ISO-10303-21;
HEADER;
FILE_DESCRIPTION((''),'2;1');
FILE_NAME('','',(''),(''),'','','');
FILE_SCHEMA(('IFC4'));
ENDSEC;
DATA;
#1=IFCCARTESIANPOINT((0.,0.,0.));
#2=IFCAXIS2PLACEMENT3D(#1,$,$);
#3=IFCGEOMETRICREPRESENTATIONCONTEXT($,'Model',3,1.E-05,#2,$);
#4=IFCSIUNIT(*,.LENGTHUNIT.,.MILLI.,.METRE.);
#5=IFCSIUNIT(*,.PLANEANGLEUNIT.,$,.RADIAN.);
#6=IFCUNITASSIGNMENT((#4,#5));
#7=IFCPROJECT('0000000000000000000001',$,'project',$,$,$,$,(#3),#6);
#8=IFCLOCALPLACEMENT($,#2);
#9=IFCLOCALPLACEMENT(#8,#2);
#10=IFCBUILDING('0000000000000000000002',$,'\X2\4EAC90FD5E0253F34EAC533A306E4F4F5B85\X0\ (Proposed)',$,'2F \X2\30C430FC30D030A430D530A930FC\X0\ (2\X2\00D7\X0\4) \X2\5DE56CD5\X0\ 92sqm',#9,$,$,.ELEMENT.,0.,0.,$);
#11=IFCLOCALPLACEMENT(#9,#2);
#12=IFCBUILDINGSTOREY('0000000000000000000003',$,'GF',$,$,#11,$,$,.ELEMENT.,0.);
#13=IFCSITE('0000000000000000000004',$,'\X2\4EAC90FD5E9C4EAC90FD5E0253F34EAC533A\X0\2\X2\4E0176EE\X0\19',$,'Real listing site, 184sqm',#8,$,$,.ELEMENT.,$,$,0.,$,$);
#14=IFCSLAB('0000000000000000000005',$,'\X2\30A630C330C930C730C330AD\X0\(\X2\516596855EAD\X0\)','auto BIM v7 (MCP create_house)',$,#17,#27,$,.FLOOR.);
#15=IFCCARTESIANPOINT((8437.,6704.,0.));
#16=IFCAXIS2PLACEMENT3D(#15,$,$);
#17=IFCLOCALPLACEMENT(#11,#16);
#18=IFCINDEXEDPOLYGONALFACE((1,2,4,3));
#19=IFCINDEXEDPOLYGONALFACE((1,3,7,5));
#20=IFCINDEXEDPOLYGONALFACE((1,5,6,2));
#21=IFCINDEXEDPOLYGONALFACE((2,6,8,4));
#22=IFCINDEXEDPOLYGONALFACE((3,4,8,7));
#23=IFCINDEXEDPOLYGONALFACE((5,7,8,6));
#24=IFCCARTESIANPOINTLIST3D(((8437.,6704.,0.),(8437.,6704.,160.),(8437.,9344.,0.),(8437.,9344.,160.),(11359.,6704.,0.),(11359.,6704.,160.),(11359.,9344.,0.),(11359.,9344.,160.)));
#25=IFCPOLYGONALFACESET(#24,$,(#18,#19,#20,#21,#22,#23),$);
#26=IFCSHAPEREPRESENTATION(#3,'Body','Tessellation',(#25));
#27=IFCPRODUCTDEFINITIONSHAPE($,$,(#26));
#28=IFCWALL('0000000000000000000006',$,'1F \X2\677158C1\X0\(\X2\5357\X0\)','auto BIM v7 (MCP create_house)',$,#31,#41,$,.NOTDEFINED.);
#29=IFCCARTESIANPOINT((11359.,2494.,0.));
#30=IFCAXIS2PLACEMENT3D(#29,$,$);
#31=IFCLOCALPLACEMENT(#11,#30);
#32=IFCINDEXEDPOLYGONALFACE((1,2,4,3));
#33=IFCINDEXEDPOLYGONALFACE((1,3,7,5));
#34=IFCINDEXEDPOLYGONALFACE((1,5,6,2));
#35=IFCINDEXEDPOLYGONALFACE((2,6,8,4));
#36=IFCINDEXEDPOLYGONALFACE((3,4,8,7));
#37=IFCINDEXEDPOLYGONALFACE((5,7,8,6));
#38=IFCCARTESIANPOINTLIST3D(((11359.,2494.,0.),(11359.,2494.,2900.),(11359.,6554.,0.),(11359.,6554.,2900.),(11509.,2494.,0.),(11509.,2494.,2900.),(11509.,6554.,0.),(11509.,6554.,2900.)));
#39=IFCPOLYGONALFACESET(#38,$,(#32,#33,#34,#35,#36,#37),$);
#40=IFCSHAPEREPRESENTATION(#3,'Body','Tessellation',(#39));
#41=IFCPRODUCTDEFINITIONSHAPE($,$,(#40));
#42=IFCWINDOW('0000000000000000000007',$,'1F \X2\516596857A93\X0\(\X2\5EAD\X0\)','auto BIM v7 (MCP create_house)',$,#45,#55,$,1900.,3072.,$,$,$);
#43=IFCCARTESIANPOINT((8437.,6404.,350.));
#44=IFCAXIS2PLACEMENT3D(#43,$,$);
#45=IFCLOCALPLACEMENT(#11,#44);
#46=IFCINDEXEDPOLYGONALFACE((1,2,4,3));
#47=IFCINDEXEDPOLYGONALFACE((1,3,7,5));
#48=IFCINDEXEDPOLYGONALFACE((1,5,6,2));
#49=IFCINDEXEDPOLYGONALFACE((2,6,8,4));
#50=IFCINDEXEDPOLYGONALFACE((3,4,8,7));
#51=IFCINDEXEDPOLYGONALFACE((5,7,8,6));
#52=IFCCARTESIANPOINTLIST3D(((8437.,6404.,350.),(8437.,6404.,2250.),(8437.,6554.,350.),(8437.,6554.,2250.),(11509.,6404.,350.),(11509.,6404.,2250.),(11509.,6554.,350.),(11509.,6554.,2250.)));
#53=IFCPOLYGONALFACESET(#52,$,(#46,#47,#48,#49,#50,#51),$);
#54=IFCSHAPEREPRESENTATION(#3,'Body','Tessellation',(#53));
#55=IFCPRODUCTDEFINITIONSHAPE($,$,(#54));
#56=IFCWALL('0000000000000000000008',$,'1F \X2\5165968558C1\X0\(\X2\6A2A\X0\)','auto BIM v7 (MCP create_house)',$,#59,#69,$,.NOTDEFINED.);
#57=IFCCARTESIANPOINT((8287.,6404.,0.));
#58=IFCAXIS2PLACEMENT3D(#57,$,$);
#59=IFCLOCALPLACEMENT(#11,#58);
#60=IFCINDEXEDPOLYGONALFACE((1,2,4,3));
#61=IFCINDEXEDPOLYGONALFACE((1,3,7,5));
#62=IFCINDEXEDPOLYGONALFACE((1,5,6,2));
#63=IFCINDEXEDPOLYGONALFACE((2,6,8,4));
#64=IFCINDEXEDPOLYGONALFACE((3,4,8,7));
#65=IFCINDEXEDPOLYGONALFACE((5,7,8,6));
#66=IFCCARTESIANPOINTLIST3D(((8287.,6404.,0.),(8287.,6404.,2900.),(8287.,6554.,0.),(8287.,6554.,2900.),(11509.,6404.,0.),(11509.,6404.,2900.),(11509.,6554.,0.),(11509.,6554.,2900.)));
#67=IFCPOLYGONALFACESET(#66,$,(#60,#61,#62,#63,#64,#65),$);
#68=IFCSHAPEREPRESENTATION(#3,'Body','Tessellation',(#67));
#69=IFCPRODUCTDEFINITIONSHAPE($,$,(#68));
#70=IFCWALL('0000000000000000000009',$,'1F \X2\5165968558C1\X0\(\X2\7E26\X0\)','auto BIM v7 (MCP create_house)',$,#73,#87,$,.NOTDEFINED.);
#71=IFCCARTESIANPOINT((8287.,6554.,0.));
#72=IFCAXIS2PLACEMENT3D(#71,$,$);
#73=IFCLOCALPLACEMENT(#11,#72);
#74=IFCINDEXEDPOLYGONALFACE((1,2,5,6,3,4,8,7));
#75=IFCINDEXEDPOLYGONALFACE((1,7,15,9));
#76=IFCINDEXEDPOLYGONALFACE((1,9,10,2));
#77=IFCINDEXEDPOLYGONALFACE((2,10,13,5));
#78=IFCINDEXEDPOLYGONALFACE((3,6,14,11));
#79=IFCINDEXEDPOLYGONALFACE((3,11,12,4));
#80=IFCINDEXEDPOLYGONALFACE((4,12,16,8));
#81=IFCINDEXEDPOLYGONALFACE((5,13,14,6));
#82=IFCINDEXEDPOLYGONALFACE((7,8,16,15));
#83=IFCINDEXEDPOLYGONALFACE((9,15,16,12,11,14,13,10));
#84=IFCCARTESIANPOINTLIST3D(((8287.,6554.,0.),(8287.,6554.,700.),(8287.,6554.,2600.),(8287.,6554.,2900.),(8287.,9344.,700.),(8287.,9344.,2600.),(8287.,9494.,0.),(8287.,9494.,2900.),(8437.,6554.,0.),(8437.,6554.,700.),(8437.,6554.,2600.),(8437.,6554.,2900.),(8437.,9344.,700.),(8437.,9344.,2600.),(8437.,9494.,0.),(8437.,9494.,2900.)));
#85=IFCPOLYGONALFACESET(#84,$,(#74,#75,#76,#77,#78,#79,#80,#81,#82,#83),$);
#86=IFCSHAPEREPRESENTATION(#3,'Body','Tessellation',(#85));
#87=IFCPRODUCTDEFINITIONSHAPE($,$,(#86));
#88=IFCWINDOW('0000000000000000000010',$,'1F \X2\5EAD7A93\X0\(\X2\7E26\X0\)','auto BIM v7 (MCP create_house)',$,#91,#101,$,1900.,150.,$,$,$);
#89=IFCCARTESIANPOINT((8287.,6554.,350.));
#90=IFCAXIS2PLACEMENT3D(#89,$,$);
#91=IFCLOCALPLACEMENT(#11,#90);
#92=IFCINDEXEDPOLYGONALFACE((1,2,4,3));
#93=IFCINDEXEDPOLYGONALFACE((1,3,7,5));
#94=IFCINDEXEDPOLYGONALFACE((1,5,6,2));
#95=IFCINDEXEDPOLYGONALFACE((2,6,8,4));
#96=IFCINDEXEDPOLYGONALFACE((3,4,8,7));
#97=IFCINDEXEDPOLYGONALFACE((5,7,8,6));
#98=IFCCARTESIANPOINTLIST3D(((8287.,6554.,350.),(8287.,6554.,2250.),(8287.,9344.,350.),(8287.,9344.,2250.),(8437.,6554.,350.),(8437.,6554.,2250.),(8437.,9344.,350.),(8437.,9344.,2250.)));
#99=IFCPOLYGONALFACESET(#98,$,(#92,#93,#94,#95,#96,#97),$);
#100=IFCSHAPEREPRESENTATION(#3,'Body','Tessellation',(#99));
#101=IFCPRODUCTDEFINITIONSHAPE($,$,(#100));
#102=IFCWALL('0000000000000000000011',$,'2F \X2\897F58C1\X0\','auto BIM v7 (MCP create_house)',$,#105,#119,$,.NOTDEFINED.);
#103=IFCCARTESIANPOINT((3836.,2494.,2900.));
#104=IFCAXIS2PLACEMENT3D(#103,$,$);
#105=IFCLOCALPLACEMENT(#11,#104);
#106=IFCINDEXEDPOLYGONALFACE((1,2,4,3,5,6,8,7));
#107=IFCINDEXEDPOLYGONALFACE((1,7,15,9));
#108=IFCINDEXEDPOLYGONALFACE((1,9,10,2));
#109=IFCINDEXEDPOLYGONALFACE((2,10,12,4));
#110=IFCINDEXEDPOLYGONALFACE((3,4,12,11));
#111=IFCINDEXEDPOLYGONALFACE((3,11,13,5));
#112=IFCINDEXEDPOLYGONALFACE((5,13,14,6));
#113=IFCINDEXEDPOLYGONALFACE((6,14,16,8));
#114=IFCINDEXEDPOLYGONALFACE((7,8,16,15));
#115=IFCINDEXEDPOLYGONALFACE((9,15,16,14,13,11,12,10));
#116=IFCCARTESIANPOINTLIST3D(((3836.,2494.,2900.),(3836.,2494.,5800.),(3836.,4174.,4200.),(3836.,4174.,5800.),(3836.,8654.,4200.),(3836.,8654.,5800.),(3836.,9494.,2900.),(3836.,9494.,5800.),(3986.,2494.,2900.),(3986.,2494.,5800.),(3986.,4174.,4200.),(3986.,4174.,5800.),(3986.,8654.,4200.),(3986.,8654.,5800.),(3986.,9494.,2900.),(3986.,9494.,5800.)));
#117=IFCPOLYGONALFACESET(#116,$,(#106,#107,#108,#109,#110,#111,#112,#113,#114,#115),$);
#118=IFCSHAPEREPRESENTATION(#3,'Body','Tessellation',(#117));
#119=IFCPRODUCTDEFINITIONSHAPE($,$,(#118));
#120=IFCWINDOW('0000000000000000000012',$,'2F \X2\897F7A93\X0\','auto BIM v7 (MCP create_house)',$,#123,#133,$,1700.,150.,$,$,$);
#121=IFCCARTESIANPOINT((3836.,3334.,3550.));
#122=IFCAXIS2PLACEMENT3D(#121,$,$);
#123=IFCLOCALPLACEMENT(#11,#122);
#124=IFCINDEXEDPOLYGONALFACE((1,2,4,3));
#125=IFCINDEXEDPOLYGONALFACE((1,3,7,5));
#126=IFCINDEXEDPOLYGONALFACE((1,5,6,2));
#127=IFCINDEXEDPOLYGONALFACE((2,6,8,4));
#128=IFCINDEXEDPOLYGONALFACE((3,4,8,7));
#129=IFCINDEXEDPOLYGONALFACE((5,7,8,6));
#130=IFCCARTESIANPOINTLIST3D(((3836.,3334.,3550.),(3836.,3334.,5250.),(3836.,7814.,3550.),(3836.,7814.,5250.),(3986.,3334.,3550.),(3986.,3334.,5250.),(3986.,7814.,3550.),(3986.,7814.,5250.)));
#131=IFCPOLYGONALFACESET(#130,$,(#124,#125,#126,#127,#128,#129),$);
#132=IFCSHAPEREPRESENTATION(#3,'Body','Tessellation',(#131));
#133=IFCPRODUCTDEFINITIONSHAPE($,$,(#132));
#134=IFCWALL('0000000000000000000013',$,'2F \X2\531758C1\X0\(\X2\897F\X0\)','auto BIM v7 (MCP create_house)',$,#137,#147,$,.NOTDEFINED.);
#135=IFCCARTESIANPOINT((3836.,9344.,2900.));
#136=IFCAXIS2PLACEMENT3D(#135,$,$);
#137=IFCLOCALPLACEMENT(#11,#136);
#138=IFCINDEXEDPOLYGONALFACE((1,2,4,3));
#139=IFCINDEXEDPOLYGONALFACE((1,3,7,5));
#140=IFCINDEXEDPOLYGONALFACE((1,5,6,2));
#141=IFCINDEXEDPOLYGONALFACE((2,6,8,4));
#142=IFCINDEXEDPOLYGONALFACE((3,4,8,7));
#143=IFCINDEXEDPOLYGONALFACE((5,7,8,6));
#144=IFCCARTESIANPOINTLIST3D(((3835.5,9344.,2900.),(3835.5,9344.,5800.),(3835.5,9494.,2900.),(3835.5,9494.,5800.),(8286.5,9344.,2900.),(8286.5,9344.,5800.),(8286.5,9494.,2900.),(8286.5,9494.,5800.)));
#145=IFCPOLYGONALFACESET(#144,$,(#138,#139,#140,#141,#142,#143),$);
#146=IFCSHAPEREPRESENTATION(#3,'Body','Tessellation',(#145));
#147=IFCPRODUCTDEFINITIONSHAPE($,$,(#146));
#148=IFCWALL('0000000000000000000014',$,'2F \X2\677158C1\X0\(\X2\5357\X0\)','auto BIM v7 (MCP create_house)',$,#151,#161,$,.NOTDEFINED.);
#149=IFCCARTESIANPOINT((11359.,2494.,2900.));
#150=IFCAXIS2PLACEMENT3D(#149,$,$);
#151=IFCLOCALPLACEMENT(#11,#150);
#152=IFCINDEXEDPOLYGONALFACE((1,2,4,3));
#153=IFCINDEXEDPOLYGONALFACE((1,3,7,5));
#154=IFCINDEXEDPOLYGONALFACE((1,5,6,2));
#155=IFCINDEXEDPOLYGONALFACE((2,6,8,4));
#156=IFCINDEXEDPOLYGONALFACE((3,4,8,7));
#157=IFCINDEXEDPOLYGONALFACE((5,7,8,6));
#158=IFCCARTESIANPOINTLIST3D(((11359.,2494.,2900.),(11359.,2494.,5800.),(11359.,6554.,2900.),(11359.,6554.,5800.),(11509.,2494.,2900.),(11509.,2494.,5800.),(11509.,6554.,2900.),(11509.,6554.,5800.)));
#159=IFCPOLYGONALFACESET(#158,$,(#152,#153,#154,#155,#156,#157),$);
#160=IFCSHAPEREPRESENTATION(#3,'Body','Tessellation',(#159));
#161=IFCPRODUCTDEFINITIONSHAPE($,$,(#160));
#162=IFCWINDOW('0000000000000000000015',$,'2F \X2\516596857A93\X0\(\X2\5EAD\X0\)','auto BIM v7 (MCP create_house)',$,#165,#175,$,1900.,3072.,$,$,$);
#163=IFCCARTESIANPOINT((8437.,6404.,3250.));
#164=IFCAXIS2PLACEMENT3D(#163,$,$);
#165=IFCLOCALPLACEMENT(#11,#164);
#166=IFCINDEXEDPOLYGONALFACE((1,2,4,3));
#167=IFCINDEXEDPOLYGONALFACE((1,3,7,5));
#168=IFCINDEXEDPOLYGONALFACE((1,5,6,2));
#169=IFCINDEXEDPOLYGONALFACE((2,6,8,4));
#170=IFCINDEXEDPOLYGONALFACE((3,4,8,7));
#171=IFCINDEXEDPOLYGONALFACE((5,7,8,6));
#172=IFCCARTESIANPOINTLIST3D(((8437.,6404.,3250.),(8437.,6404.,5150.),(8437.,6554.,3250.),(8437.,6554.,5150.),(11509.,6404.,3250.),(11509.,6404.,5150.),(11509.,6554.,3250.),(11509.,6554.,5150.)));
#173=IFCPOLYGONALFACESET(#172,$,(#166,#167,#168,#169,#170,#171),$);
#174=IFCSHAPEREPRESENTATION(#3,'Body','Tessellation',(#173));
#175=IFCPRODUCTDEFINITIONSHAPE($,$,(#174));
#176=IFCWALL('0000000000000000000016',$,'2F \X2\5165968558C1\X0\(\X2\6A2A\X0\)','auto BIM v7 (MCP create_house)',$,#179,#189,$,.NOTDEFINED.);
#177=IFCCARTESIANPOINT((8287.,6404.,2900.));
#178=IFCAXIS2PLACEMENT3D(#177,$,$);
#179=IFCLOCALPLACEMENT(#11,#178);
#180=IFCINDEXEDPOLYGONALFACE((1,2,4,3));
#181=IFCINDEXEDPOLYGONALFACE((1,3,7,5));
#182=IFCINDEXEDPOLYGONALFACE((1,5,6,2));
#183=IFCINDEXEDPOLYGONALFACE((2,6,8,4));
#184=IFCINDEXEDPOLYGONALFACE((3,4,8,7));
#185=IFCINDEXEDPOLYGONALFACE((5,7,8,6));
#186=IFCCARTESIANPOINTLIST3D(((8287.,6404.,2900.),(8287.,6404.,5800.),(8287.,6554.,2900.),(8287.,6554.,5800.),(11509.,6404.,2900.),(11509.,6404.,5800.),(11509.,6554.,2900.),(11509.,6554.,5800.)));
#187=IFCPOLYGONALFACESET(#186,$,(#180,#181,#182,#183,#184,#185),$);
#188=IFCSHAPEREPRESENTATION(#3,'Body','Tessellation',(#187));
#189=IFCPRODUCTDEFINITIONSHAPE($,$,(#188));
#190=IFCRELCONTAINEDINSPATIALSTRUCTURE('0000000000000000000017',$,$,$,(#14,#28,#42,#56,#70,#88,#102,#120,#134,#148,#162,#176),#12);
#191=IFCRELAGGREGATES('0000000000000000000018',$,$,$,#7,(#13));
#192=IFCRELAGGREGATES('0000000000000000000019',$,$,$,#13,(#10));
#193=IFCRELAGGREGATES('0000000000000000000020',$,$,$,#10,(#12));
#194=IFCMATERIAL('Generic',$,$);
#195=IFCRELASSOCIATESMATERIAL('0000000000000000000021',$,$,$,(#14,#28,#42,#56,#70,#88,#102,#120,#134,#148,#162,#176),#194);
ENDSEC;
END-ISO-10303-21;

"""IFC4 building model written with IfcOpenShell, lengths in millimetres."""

from ifc_helpers import new_model, si_unit, frame, frame_2d, origin, place, context, project, spatial, rectangle, extrude, material, element, fill, save


model = new_model("IFC4")

# Units and contexts
model_context = context("Model", 3, precision=1e-05, world=origin())
ifc_project = project(units=[si_unit("LENGTHUNIT", "METRE", prefix="MILLI"), si_unit("PLANEANGLEUNIT", "RADIAN")], contexts=[model_context])

# Site, building, storey
site_placement = place(None, origin())
site = spatial("IfcSite", under=ifc_project, at=site_placement, Name="京都府京都市右京区2丁目19", ObjectType="Real listing site, 184sqm", CompositionType="ELEMENT", RefElevation=0.0)
building_placement = place(site_placement, origin())
building = spatial("IfcBuilding", under=site, at=building_placement, Name="京都市右京区の住宅 (Proposed)", ObjectType="2F ツーバイフォー (2×4) 工法 92sqm", CompositionType="ELEMENT", ElevationOfRefHeight=0.0, ElevationOfTerrain=0.0)
storey_placement = place(building_placement, origin())
storey = spatial("IfcBuildingStorey", under=building, at=storey_placement, Name="GF", CompositionType="ELEMENT", Elevation=0.0)

# Slab
ifc_material = material(Name="Generic")
slab_placement = place(storey_placement, frame((8437.0, 6704.0, 0.0)))
element("IfcSlab", 1, at=slab_placement, inside=storey, material=ifc_material, Name="ウッドデッキ(入隅庭)", Description="auto BIM v7 (MCP create_house)", PredefinedType="FLOOR", context=model_context, shape_type="SweptSolid", body=[
    extrude(rectangle(XDim=2922.0, YDim=2640.0, at=frame_2d((1461.0, 1320.0))), frame((8437.0, 6704.0, 0.0)), (0.0, 0.0, 1.0), 160.0),
])

# Wall, opening, window
wall_1_placement = place(storey_placement, frame((11359.0, 2494.0, 0.0)))
wall_1 = element("IfcWall", 2, at=wall_1_placement, inside=storey, material=ifc_material, Name="1F 東壁(南)", Description="auto BIM v7 (MCP create_house)", PredefinedType="NOTDEFINED", context=model_context, shape_type="SweptSolid", body=[
    extrude(rectangle(XDim=150.0, YDim=4060.0, at=frame_2d((75.0, 2030.0))), frame((11359.0, 2494.0, 0.0)), (0.0, 0.0, 1.0), 2900.0),
])
opening_1_placement = place(storey_placement, frame((8437.0, 6404.0, 350.0)))
opening_1 = element("IfcOpeningElement", 3, at=opening_1_placement, cuts=wall_1, PredefinedType="NOTDEFINED", context=model_context, shape_type="SweptSolid", body=[
    extrude(rectangle(XDim=3072.0, YDim=150.0, at=frame_2d((1536.0, 75.0))), frame((8437.0, 6404.0, 350.0)), (0.0, 0.0, 1.0), 1900.0),
])
window_1_placement = place(storey_placement, frame((8437.0, 6404.0, 350.0)))
window_1 = element("IfcWindow", 4, at=window_1_placement, inside=storey, material=ifc_material, Name="1F 入隅窓(庭)", Description="auto BIM v7 (MCP create_house)", OverallHeight=1900.0, OverallWidth=3072.0, context=model_context, shape_type="SweptSolid", body=[
    extrude(rectangle(XDim=3072.0, YDim=150.0, at=frame_2d((1536.0, 75.0))), frame((8437.0, 6404.0, 350.0)), (0.0, 0.0, 1.0), 1900.0),
])
fill(opening_1, window_1)

# Wall
wall_2_placement = place(storey_placement, frame((8287.0, 6404.0, 0.0)))
element("IfcWall", 5, at=wall_2_placement, inside=storey, material=ifc_material, Name="1F 入隅壁(横)", Description="auto BIM v7 (MCP create_house)", PredefinedType="NOTDEFINED", context=model_context, shape_type="SweptSolid", body=[
    extrude(rectangle(XDim=3222.0, YDim=150.0, at=frame_2d((1611.0, 75.0))), frame((8287.0, 6404.0, 0.0)), (0.0, 0.0, 1.0), 2900.0),
])

# Wall, opening, window
wall_3_placement = place(storey_placement, frame((8287.0, 6554.0, 0.0)))
wall_3 = element("IfcWall", 6, at=wall_3_placement, inside=storey, material=ifc_material, Name="1F 入隅壁(縦)", Description="auto BIM v7 (MCP create_house)", PredefinedType="NOTDEFINED", context=model_context, shape_type="SweptSolid", body=[
    extrude(rectangle(XDim=150.0, YDim=2940.0, at=frame_2d((75.0, 1470.0))), frame((8287.0, 6554.0, 0.0)), (0.0, 0.0, 1.0), 2900.0),
])
opening_2_placement = place(storey_placement, frame((8287.0, 6554.0, 350.0)))
opening_2 = element("IfcOpeningElement", 7, at=opening_2_placement, cuts=wall_3, PredefinedType="NOTDEFINED", context=model_context, shape_type="SweptSolid", body=[
    extrude(rectangle(XDim=150.0, YDim=2790.0, at=frame_2d((75.0, 1395.0))), frame((8287.0, 6554.0, 350.0)), (0.0, 0.0, 1.0), 1900.0),
])
window_2_placement = place(storey_placement, frame((8287.0, 6554.0, 350.0)))
window_2 = element("IfcWindow", 8, at=window_2_placement, inside=storey, material=ifc_material, Name="1F 庭窓(縦)", Description="auto BIM v7 (MCP create_house)", OverallHeight=1900.0, OverallWidth=150.0, context=model_context, shape_type="SweptSolid", body=[
    extrude(rectangle(XDim=150.0, YDim=2790.0, at=frame_2d((75.0, 1395.0))), frame((8287.0, 6554.0, 350.0)), (0.0, 0.0, 1.0), 1900.0),
])
fill(opening_2, window_2)

# Wall, opening, window
wall_4_placement = place(storey_placement, frame((3836.0, 2494.0, 2900.0)))
wall_4 = element("IfcWall", 9, at=wall_4_placement, inside=storey, material=ifc_material, Name="2F 西壁", Description="auto BIM v7 (MCP create_house)", PredefinedType="NOTDEFINED", context=model_context, shape_type="SweptSolid", body=[
    extrude(rectangle(XDim=150.0, YDim=7000.0, at=frame_2d((75.0, 3500.0))), frame((3836.0, 2494.0, 2900.0)), (0.0, 0.0, 1.0), 2900.0),
])
opening_3_placement = place(storey_placement, frame((3836.0, 3334.0, 3550.0)))
opening_3 = element("IfcOpeningElement", 10, at=opening_3_placement, cuts=wall_4, PredefinedType="NOTDEFINED", context=model_context, shape_type="SweptSolid", body=[
    extrude(rectangle(XDim=150.0, YDim=4480.0, at=frame_2d((75.0, 2240.0))), frame((3836.0, 3334.0, 3550.0)), (0.0, 0.0, 1.0), 1700.0),
])
window_3_placement = place(storey_placement, frame((3836.0, 3334.0, 3550.0)))
window_3 = element("IfcWindow", 11, at=window_3_placement, inside=storey, material=ifc_material, Name="2F 西窓", Description="auto BIM v7 (MCP create_house)", OverallHeight=1700.0, OverallWidth=150.0, context=model_context, shape_type="SweptSolid", body=[
    extrude(rectangle(XDim=150.0, YDim=4480.0, at=frame_2d((75.0, 2240.0))), frame((3836.0, 3334.0, 3550.0)), (0.0, 0.0, 1.0), 1700.0),
])
fill(opening_3, window_3)

# Wall
wall_5_placement = place(storey_placement, frame((3836.0, 9344.0, 2900.0)))
element("IfcWall", 12, at=wall_5_placement, inside=storey, material=ifc_material, Name="2F 北壁(西)", Description="auto BIM v7 (MCP create_house)", PredefinedType="NOTDEFINED", context=model_context, shape_type="SweptSolid", body=[
    extrude(rectangle(XDim=4451.0, YDim=150.0, at=frame_2d((2225.0, 75.0))), frame((3836.0, 9344.0, 2900.0)), (0.0, 0.0, 1.0), 2900.0),
])

# Wall, opening, window
wall_6_placement = place(storey_placement, frame((11359.0, 2494.0, 2900.0)))
wall_6 = element("IfcWall", 13, at=wall_6_placement, inside=storey, material=ifc_material, Name="2F 東壁(南)", Description="auto BIM v7 (MCP create_house)", PredefinedType="NOTDEFINED", context=model_context, shape_type="SweptSolid", body=[
    extrude(rectangle(XDim=150.0, YDim=4060.0, at=frame_2d((75.0, 2030.0))), frame((11359.0, 2494.0, 2900.0)), (0.0, 0.0, 1.0), 2900.0),
])
opening_4_placement = place(storey_placement, frame((8437.0, 6404.0, 3250.0)))
opening_4 = element("IfcOpeningElement", 14, at=opening_4_placement, cuts=wall_6, PredefinedType="NOTDEFINED", context=model_context, shape_type="SweptSolid", body=[
    extrude(rectangle(XDim=3072.0, YDim=150.0, at=frame_2d((1536.0, 75.0))), frame((8437.0, 6404.0, 3250.0)), (0.0, 0.0, 1.0), 1900.0),
])
window_4_placement = place(storey_placement, frame((8437.0, 6404.0, 3250.0)))
window_4 = element("IfcWindow", 15, at=window_4_placement, inside=storey, material=ifc_material, Name="2F 入隅窓(庭)", Description="auto BIM v7 (MCP create_house)", OverallHeight=1900.0, OverallWidth=3072.0, context=model_context, shape_type="SweptSolid", body=[
    extrude(rectangle(XDim=3072.0, YDim=150.0, at=frame_2d((1536.0, 75.0))), frame((8437.0, 6404.0, 3250.0)), (0.0, 0.0, 1.0), 1900.0),
])
fill(opening_4, window_4)

# Wall
wall_7_placement = place(storey_placement, frame((8287.0, 6404.0, 2900.0)))
element("IfcWall", 16, at=wall_7_placement, inside=storey, material=ifc_material, Name="2F 入隅壁(横)", Description="auto BIM v7 (MCP create_house)", PredefinedType="NOTDEFINED", context=model_context, shape_type="SweptSolid", body=[
    extrude(rectangle(XDim=3222.0, YDim=150.0, at=frame_2d((1611.0, 75.0))), frame((8287.0, 6404.0, 2900.0)), (0.0, 0.0, 1.0), 2900.0),
])

save(model, "model.ifc")
